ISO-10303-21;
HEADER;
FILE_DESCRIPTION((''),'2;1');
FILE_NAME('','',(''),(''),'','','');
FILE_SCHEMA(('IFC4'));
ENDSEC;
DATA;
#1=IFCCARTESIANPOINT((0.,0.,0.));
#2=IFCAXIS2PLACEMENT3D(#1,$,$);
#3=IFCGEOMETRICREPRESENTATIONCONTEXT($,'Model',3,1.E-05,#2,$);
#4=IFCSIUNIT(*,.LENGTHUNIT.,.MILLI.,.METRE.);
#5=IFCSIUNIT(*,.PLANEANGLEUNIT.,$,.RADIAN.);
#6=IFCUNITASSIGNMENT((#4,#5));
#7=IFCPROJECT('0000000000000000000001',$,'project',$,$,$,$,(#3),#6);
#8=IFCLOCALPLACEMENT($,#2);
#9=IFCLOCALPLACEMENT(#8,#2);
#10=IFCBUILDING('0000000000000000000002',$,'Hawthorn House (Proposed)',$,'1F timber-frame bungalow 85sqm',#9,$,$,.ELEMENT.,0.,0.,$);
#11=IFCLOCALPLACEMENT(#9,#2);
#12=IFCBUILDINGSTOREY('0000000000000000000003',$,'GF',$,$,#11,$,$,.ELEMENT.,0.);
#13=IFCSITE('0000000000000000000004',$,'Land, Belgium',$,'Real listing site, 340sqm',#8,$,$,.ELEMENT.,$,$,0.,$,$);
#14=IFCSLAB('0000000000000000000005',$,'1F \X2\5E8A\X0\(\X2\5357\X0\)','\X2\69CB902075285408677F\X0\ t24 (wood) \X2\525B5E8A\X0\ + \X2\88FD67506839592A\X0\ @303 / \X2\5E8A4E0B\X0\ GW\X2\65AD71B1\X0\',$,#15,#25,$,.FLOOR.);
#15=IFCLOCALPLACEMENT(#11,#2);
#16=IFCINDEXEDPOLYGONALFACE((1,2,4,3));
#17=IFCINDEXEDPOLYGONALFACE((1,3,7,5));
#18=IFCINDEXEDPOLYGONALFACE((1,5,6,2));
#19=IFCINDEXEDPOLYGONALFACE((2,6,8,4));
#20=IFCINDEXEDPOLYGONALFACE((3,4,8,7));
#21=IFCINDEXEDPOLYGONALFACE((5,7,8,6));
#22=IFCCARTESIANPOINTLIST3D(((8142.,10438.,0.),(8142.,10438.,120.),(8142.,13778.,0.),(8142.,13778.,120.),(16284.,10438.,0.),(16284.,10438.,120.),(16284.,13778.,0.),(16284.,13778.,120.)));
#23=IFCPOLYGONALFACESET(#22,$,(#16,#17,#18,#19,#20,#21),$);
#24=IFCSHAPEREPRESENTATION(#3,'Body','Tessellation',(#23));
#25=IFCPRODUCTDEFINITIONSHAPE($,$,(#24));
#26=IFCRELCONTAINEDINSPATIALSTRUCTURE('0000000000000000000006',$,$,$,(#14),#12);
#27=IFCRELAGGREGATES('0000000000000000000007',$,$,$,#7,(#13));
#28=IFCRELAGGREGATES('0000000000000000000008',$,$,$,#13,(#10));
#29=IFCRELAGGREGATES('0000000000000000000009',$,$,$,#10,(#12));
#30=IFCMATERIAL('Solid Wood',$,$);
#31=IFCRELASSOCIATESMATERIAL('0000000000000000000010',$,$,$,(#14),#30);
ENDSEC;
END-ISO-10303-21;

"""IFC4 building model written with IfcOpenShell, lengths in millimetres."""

from ifc_helpers import new_model, si_unit, frame, frame_2d, origin, place, context, project, spatial, rectangle, extrude, material, element, save


model = new_model("IFC4")

# Units and contexts
model_context = context("Model", 3, precision=1e-05, world=origin())
ifc_project = project(units=[si_unit("LENGTHUNIT", "METRE", prefix="MILLI"), si_unit("PLANEANGLEUNIT", "RADIAN")], contexts=[model_context])

# Site, building, storey
site_placement = place(None, origin())
site = spatial("IfcSite", under=ifc_project, at=site_placement, Name="Land, Belgium", ObjectType="Real listing site, 340sqm", CompositionType="ELEMENT", RefElevation=0.0)
building_placement = place(site_placement, origin())
building = spatial("IfcBuilding", under=site, at=building_placement, Name="Hawthorn House (Proposed)", ObjectType="1F timber-frame bungalow 85sqm", CompositionType="ELEMENT", ElevationOfRefHeight=0.0, ElevationOfTerrain=0.0)
storey_placement = place(building_placement, origin())
storey = spatial("IfcBuildingStorey", under=building, at=storey_placement, Name="GF", CompositionType="ELEMENT", Elevation=0.0)

# Shared definitions
ifc_material_1 = material(Name="Solid Wood")

# Slab
slab_1_placement = place(storey_placement, frame((4071.0, 5219.0, 0.0)))
element("IfcSlab", 1, at=slab_1_placement, inside=storey, material=ifc_material_1, Name="1F 床(南)", Description="構造用合板 t24 (wood) 剛床 + 製材根太 @303 / 床下 GW断熱", PredefinedType="FLOOR", context=model_context, shape_type="SweptSolid", body=[
    extrude(rectangle(XDim=8142.0, YDim=3340.0, at=frame_2d((4071.0, 1670.0))), frame((4071.0, 5219.0, 0.0)), (0.0, 0.0, 1.0), 120.0),
])

save(model, "model.ifc")
